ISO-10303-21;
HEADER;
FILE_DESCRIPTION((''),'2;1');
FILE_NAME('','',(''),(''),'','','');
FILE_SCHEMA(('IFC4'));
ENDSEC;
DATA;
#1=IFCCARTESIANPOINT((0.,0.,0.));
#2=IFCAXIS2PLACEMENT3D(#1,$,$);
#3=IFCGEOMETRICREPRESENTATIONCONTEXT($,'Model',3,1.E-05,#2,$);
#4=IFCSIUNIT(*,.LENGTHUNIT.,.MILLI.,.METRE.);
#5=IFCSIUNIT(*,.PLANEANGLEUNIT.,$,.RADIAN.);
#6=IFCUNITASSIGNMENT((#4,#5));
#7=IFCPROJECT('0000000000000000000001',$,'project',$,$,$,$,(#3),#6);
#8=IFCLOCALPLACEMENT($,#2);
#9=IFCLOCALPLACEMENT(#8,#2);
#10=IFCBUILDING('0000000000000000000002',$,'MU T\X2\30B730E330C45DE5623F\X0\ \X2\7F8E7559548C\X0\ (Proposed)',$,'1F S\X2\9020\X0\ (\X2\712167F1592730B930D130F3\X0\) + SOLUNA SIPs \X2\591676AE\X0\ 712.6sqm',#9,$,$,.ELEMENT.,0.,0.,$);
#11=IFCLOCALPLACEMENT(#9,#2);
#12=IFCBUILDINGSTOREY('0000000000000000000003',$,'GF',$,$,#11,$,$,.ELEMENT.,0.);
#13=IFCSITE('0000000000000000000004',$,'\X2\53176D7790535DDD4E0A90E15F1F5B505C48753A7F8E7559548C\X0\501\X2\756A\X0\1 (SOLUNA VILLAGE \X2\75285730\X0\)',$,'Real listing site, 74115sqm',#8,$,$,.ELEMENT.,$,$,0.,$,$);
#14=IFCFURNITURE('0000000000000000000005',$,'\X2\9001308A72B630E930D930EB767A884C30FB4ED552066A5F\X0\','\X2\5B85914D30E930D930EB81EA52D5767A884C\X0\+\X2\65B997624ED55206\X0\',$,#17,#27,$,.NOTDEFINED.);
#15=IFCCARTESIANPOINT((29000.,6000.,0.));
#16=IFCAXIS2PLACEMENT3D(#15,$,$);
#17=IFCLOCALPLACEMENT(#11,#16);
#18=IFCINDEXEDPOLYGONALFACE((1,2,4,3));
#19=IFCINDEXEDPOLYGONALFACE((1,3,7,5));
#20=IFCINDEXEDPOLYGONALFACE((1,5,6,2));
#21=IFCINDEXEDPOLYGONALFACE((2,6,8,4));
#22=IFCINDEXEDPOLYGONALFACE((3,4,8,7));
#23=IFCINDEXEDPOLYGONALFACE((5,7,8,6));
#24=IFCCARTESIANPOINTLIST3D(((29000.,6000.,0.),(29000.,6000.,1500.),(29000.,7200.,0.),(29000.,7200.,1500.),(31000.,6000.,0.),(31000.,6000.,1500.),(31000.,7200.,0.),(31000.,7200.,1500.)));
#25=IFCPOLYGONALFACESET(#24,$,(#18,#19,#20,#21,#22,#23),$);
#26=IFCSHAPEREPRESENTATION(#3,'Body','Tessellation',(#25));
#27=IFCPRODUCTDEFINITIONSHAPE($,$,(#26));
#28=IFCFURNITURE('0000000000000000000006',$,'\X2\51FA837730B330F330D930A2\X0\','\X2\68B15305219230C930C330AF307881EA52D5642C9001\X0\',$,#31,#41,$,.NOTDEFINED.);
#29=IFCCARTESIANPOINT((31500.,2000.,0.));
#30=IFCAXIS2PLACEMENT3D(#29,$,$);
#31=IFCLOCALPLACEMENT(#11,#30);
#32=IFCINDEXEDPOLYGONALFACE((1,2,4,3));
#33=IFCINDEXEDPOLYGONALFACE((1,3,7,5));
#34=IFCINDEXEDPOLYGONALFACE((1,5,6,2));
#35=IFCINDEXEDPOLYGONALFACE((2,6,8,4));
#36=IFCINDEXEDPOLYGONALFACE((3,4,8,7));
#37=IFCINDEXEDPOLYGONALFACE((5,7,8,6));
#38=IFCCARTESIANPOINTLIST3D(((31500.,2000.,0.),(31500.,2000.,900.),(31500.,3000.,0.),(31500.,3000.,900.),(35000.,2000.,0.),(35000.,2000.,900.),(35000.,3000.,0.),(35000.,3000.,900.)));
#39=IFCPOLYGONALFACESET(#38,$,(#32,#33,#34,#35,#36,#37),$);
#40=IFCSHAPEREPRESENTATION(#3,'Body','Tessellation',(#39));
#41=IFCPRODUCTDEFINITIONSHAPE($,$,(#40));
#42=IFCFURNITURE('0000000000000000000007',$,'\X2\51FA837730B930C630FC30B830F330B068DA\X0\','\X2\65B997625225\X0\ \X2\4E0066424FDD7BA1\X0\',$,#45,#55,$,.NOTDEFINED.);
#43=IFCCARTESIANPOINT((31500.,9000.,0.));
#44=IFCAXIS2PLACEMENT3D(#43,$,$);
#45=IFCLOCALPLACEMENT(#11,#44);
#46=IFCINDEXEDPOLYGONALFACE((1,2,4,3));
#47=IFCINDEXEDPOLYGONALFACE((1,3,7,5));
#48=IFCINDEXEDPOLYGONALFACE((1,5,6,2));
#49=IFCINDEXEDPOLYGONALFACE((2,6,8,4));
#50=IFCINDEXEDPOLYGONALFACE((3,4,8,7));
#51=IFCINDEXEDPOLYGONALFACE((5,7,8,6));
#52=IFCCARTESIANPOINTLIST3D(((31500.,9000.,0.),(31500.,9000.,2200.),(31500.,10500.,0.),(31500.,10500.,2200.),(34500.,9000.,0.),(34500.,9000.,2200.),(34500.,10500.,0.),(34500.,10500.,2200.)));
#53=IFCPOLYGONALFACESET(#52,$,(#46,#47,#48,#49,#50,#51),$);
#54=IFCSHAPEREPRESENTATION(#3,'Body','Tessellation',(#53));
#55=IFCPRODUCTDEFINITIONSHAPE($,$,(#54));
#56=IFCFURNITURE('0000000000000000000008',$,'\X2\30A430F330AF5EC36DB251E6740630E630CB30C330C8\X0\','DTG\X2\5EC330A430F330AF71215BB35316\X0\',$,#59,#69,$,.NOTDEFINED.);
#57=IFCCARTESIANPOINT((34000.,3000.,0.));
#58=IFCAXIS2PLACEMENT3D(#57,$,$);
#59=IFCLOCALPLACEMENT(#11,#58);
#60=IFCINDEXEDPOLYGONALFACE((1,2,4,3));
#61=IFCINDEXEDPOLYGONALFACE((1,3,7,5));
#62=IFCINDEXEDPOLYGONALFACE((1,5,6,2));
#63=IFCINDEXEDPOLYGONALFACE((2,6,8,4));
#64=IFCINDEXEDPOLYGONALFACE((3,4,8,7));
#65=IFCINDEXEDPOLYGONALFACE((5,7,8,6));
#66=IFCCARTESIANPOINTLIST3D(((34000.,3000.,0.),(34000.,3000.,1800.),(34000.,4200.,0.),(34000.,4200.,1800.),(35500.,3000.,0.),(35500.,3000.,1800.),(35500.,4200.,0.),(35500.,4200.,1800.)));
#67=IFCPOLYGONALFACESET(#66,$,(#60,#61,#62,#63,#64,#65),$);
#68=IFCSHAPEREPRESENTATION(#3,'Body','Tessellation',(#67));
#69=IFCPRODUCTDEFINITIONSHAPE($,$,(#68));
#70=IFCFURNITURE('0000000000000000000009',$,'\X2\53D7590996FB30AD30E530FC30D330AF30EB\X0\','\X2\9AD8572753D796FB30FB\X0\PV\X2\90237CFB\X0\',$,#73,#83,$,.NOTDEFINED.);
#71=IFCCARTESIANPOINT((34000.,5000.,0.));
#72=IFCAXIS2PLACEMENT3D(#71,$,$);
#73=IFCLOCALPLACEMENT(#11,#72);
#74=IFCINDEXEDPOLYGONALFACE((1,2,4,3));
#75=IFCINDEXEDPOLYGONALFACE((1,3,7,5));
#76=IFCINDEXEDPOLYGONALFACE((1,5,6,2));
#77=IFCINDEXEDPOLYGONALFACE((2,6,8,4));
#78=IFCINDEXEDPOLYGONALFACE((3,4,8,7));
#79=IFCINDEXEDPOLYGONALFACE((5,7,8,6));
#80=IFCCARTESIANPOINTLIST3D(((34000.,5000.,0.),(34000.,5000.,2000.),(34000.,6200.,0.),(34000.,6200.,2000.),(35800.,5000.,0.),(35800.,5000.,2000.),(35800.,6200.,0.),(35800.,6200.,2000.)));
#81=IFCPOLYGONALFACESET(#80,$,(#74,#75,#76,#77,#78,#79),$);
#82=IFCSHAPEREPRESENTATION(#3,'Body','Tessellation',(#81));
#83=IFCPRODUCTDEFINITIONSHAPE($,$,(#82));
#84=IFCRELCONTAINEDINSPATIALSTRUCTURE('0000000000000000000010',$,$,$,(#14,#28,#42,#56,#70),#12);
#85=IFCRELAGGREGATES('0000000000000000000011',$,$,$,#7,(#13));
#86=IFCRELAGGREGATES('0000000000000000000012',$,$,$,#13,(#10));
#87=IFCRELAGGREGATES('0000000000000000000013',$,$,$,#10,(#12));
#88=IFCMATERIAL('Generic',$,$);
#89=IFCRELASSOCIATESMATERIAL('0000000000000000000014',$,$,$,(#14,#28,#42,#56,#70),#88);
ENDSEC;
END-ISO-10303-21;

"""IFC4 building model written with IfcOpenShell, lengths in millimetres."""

from ifc_helpers import new_model, si_unit, frame, frame_2d, origin, place, context, project, spatial, rectangle, extrude, material, element, save


model = new_model("IFC4")

# Units and contexts
model_context = context("Model", 3, precision=1e-05, world=origin())
ifc_project = project(units=[si_unit("LENGTHUNIT", "METRE", prefix="MILLI"), si_unit("PLANEANGLEUNIT", "RADIAN")], contexts=[model_context])

# Site, building, storey
site_placement = place(None, origin())
site = spatial("IfcSite", under=ifc_project, at=site_placement, Name="北海道川上郡弟子屈町美留和501番1 (SOLUNA VILLAGE 用地)", ObjectType="Real listing site, 74115sqm", CompositionType="ELEMENT", RefElevation=0.0)
building_placement = place(site_placement, origin())
building = spatial("IfcBuilding", under=site, at=building_placement, Name="MU Tシャツ工房 美留和 (Proposed)", ObjectType="1F S造 (無柱大スパン) + SOLUNA SIPs 外皮 712.6sqm", CompositionType="ELEMENT", ElevationOfRefHeight=0.0, ElevationOfTerrain=0.0)
storey_placement = place(building_placement, origin())
storey = spatial("IfcBuildingStorey", under=building, at=storey_placement, Name="GF", CompositionType="ELEMENT", Elevation=0.0)

# Shared definitions
ifc_material_1 = material(Name="Generic")

# Furniture
furniture_1_placement = place(storey_placement, frame((29000.0, 6000.0, 0.0)))
element("IfcFurniture", 1, at=furniture_1_placement, inside=storey, material=ifc_material_1, Name="送り状ラベル発行・仕分機", Description="宅配ラベル自動発行+方面仕分", PredefinedType="NOTDEFINED", context=model_context, shape_type="SweptSolid", body=[
    extrude(rectangle(XDim=2000.0, YDim=1200.0, at=frame_2d((1000.0, 600.0))), frame((29000.0, 6000.0, 0.0)), (0.0, 0.0, 1.0), 1500.0),
])
furniture_2_placement = place(storey_placement, frame((31500.0, 2000.0, 0.0)))
element("IfcFurniture", 2, at=furniture_2_placement, inside=storey, material=ifc_material_1, Name="出荷コンベア", Description="梱包→ドックへ自動搬送", PredefinedType="NOTDEFINED", context=model_context, shape_type="SweptSolid", body=[
    extrude(rectangle(XDim=3500.0, YDim=1000.0, at=frame_2d((1750.0, 500.0))), frame((31500.0, 2000.0, 0.0)), (0.0, 0.0, 1.0), 900.0),
])
furniture_3_placement = place(storey_placement, frame((31500.0, 9000.0, 0.0)))
element("IfcFurniture", 3, at=furniture_3_placement, inside=storey, material=ifc_material_1, Name="出荷ステージング棚", Description="方面別 一時保管", PredefinedType="NOTDEFINED", context=model_context, shape_type="SweptSolid", body=[
    extrude(rectangle(XDim=3000.0, YDim=1500.0, at=frame_2d((1500.0, 750.0))), frame((31500.0, 9000.0, 0.0)), (0.0, 0.0, 1.0), 2200.0),
])
furniture_4_placement = place(storey_placement, frame((34000.0, 3000.0, 0.0)))
element("IfcFurniture", 4, at=furniture_4_placement, inside=storey, material=ifc_material_1, Name="インク廃液処理ユニット", Description="DTG廃インク無害化", PredefinedType="NOTDEFINED", context=model_context, shape_type="SweptSolid", body=[
    extrude(rectangle(XDim=1500.0, YDim=1200.0, at=frame_2d((750.0, 600.0))), frame((34000.0, 3000.0, 0.0)), (0.0, 0.0, 1.0), 1800.0),
])
furniture_5_placement = place(storey_placement, frame((34000.0, 5000.0, 0.0)))
element("IfcFurniture", 5, at=furniture_5_placement, inside=storey, material=ifc_material_1, Name="受変電キュービクル", Description="高圧受電・PV連系", PredefinedType="NOTDEFINED", context=model_context, shape_type="SweptSolid", body=[
    extrude(rectangle(XDim=1800.0, YDim=1200.0, at=frame_2d((900.0, 600.0))), frame((34000.0, 5000.0, 0.0)), (0.0, 0.0, 1.0), 2000.0),
])

save(model, "model.ifc")
